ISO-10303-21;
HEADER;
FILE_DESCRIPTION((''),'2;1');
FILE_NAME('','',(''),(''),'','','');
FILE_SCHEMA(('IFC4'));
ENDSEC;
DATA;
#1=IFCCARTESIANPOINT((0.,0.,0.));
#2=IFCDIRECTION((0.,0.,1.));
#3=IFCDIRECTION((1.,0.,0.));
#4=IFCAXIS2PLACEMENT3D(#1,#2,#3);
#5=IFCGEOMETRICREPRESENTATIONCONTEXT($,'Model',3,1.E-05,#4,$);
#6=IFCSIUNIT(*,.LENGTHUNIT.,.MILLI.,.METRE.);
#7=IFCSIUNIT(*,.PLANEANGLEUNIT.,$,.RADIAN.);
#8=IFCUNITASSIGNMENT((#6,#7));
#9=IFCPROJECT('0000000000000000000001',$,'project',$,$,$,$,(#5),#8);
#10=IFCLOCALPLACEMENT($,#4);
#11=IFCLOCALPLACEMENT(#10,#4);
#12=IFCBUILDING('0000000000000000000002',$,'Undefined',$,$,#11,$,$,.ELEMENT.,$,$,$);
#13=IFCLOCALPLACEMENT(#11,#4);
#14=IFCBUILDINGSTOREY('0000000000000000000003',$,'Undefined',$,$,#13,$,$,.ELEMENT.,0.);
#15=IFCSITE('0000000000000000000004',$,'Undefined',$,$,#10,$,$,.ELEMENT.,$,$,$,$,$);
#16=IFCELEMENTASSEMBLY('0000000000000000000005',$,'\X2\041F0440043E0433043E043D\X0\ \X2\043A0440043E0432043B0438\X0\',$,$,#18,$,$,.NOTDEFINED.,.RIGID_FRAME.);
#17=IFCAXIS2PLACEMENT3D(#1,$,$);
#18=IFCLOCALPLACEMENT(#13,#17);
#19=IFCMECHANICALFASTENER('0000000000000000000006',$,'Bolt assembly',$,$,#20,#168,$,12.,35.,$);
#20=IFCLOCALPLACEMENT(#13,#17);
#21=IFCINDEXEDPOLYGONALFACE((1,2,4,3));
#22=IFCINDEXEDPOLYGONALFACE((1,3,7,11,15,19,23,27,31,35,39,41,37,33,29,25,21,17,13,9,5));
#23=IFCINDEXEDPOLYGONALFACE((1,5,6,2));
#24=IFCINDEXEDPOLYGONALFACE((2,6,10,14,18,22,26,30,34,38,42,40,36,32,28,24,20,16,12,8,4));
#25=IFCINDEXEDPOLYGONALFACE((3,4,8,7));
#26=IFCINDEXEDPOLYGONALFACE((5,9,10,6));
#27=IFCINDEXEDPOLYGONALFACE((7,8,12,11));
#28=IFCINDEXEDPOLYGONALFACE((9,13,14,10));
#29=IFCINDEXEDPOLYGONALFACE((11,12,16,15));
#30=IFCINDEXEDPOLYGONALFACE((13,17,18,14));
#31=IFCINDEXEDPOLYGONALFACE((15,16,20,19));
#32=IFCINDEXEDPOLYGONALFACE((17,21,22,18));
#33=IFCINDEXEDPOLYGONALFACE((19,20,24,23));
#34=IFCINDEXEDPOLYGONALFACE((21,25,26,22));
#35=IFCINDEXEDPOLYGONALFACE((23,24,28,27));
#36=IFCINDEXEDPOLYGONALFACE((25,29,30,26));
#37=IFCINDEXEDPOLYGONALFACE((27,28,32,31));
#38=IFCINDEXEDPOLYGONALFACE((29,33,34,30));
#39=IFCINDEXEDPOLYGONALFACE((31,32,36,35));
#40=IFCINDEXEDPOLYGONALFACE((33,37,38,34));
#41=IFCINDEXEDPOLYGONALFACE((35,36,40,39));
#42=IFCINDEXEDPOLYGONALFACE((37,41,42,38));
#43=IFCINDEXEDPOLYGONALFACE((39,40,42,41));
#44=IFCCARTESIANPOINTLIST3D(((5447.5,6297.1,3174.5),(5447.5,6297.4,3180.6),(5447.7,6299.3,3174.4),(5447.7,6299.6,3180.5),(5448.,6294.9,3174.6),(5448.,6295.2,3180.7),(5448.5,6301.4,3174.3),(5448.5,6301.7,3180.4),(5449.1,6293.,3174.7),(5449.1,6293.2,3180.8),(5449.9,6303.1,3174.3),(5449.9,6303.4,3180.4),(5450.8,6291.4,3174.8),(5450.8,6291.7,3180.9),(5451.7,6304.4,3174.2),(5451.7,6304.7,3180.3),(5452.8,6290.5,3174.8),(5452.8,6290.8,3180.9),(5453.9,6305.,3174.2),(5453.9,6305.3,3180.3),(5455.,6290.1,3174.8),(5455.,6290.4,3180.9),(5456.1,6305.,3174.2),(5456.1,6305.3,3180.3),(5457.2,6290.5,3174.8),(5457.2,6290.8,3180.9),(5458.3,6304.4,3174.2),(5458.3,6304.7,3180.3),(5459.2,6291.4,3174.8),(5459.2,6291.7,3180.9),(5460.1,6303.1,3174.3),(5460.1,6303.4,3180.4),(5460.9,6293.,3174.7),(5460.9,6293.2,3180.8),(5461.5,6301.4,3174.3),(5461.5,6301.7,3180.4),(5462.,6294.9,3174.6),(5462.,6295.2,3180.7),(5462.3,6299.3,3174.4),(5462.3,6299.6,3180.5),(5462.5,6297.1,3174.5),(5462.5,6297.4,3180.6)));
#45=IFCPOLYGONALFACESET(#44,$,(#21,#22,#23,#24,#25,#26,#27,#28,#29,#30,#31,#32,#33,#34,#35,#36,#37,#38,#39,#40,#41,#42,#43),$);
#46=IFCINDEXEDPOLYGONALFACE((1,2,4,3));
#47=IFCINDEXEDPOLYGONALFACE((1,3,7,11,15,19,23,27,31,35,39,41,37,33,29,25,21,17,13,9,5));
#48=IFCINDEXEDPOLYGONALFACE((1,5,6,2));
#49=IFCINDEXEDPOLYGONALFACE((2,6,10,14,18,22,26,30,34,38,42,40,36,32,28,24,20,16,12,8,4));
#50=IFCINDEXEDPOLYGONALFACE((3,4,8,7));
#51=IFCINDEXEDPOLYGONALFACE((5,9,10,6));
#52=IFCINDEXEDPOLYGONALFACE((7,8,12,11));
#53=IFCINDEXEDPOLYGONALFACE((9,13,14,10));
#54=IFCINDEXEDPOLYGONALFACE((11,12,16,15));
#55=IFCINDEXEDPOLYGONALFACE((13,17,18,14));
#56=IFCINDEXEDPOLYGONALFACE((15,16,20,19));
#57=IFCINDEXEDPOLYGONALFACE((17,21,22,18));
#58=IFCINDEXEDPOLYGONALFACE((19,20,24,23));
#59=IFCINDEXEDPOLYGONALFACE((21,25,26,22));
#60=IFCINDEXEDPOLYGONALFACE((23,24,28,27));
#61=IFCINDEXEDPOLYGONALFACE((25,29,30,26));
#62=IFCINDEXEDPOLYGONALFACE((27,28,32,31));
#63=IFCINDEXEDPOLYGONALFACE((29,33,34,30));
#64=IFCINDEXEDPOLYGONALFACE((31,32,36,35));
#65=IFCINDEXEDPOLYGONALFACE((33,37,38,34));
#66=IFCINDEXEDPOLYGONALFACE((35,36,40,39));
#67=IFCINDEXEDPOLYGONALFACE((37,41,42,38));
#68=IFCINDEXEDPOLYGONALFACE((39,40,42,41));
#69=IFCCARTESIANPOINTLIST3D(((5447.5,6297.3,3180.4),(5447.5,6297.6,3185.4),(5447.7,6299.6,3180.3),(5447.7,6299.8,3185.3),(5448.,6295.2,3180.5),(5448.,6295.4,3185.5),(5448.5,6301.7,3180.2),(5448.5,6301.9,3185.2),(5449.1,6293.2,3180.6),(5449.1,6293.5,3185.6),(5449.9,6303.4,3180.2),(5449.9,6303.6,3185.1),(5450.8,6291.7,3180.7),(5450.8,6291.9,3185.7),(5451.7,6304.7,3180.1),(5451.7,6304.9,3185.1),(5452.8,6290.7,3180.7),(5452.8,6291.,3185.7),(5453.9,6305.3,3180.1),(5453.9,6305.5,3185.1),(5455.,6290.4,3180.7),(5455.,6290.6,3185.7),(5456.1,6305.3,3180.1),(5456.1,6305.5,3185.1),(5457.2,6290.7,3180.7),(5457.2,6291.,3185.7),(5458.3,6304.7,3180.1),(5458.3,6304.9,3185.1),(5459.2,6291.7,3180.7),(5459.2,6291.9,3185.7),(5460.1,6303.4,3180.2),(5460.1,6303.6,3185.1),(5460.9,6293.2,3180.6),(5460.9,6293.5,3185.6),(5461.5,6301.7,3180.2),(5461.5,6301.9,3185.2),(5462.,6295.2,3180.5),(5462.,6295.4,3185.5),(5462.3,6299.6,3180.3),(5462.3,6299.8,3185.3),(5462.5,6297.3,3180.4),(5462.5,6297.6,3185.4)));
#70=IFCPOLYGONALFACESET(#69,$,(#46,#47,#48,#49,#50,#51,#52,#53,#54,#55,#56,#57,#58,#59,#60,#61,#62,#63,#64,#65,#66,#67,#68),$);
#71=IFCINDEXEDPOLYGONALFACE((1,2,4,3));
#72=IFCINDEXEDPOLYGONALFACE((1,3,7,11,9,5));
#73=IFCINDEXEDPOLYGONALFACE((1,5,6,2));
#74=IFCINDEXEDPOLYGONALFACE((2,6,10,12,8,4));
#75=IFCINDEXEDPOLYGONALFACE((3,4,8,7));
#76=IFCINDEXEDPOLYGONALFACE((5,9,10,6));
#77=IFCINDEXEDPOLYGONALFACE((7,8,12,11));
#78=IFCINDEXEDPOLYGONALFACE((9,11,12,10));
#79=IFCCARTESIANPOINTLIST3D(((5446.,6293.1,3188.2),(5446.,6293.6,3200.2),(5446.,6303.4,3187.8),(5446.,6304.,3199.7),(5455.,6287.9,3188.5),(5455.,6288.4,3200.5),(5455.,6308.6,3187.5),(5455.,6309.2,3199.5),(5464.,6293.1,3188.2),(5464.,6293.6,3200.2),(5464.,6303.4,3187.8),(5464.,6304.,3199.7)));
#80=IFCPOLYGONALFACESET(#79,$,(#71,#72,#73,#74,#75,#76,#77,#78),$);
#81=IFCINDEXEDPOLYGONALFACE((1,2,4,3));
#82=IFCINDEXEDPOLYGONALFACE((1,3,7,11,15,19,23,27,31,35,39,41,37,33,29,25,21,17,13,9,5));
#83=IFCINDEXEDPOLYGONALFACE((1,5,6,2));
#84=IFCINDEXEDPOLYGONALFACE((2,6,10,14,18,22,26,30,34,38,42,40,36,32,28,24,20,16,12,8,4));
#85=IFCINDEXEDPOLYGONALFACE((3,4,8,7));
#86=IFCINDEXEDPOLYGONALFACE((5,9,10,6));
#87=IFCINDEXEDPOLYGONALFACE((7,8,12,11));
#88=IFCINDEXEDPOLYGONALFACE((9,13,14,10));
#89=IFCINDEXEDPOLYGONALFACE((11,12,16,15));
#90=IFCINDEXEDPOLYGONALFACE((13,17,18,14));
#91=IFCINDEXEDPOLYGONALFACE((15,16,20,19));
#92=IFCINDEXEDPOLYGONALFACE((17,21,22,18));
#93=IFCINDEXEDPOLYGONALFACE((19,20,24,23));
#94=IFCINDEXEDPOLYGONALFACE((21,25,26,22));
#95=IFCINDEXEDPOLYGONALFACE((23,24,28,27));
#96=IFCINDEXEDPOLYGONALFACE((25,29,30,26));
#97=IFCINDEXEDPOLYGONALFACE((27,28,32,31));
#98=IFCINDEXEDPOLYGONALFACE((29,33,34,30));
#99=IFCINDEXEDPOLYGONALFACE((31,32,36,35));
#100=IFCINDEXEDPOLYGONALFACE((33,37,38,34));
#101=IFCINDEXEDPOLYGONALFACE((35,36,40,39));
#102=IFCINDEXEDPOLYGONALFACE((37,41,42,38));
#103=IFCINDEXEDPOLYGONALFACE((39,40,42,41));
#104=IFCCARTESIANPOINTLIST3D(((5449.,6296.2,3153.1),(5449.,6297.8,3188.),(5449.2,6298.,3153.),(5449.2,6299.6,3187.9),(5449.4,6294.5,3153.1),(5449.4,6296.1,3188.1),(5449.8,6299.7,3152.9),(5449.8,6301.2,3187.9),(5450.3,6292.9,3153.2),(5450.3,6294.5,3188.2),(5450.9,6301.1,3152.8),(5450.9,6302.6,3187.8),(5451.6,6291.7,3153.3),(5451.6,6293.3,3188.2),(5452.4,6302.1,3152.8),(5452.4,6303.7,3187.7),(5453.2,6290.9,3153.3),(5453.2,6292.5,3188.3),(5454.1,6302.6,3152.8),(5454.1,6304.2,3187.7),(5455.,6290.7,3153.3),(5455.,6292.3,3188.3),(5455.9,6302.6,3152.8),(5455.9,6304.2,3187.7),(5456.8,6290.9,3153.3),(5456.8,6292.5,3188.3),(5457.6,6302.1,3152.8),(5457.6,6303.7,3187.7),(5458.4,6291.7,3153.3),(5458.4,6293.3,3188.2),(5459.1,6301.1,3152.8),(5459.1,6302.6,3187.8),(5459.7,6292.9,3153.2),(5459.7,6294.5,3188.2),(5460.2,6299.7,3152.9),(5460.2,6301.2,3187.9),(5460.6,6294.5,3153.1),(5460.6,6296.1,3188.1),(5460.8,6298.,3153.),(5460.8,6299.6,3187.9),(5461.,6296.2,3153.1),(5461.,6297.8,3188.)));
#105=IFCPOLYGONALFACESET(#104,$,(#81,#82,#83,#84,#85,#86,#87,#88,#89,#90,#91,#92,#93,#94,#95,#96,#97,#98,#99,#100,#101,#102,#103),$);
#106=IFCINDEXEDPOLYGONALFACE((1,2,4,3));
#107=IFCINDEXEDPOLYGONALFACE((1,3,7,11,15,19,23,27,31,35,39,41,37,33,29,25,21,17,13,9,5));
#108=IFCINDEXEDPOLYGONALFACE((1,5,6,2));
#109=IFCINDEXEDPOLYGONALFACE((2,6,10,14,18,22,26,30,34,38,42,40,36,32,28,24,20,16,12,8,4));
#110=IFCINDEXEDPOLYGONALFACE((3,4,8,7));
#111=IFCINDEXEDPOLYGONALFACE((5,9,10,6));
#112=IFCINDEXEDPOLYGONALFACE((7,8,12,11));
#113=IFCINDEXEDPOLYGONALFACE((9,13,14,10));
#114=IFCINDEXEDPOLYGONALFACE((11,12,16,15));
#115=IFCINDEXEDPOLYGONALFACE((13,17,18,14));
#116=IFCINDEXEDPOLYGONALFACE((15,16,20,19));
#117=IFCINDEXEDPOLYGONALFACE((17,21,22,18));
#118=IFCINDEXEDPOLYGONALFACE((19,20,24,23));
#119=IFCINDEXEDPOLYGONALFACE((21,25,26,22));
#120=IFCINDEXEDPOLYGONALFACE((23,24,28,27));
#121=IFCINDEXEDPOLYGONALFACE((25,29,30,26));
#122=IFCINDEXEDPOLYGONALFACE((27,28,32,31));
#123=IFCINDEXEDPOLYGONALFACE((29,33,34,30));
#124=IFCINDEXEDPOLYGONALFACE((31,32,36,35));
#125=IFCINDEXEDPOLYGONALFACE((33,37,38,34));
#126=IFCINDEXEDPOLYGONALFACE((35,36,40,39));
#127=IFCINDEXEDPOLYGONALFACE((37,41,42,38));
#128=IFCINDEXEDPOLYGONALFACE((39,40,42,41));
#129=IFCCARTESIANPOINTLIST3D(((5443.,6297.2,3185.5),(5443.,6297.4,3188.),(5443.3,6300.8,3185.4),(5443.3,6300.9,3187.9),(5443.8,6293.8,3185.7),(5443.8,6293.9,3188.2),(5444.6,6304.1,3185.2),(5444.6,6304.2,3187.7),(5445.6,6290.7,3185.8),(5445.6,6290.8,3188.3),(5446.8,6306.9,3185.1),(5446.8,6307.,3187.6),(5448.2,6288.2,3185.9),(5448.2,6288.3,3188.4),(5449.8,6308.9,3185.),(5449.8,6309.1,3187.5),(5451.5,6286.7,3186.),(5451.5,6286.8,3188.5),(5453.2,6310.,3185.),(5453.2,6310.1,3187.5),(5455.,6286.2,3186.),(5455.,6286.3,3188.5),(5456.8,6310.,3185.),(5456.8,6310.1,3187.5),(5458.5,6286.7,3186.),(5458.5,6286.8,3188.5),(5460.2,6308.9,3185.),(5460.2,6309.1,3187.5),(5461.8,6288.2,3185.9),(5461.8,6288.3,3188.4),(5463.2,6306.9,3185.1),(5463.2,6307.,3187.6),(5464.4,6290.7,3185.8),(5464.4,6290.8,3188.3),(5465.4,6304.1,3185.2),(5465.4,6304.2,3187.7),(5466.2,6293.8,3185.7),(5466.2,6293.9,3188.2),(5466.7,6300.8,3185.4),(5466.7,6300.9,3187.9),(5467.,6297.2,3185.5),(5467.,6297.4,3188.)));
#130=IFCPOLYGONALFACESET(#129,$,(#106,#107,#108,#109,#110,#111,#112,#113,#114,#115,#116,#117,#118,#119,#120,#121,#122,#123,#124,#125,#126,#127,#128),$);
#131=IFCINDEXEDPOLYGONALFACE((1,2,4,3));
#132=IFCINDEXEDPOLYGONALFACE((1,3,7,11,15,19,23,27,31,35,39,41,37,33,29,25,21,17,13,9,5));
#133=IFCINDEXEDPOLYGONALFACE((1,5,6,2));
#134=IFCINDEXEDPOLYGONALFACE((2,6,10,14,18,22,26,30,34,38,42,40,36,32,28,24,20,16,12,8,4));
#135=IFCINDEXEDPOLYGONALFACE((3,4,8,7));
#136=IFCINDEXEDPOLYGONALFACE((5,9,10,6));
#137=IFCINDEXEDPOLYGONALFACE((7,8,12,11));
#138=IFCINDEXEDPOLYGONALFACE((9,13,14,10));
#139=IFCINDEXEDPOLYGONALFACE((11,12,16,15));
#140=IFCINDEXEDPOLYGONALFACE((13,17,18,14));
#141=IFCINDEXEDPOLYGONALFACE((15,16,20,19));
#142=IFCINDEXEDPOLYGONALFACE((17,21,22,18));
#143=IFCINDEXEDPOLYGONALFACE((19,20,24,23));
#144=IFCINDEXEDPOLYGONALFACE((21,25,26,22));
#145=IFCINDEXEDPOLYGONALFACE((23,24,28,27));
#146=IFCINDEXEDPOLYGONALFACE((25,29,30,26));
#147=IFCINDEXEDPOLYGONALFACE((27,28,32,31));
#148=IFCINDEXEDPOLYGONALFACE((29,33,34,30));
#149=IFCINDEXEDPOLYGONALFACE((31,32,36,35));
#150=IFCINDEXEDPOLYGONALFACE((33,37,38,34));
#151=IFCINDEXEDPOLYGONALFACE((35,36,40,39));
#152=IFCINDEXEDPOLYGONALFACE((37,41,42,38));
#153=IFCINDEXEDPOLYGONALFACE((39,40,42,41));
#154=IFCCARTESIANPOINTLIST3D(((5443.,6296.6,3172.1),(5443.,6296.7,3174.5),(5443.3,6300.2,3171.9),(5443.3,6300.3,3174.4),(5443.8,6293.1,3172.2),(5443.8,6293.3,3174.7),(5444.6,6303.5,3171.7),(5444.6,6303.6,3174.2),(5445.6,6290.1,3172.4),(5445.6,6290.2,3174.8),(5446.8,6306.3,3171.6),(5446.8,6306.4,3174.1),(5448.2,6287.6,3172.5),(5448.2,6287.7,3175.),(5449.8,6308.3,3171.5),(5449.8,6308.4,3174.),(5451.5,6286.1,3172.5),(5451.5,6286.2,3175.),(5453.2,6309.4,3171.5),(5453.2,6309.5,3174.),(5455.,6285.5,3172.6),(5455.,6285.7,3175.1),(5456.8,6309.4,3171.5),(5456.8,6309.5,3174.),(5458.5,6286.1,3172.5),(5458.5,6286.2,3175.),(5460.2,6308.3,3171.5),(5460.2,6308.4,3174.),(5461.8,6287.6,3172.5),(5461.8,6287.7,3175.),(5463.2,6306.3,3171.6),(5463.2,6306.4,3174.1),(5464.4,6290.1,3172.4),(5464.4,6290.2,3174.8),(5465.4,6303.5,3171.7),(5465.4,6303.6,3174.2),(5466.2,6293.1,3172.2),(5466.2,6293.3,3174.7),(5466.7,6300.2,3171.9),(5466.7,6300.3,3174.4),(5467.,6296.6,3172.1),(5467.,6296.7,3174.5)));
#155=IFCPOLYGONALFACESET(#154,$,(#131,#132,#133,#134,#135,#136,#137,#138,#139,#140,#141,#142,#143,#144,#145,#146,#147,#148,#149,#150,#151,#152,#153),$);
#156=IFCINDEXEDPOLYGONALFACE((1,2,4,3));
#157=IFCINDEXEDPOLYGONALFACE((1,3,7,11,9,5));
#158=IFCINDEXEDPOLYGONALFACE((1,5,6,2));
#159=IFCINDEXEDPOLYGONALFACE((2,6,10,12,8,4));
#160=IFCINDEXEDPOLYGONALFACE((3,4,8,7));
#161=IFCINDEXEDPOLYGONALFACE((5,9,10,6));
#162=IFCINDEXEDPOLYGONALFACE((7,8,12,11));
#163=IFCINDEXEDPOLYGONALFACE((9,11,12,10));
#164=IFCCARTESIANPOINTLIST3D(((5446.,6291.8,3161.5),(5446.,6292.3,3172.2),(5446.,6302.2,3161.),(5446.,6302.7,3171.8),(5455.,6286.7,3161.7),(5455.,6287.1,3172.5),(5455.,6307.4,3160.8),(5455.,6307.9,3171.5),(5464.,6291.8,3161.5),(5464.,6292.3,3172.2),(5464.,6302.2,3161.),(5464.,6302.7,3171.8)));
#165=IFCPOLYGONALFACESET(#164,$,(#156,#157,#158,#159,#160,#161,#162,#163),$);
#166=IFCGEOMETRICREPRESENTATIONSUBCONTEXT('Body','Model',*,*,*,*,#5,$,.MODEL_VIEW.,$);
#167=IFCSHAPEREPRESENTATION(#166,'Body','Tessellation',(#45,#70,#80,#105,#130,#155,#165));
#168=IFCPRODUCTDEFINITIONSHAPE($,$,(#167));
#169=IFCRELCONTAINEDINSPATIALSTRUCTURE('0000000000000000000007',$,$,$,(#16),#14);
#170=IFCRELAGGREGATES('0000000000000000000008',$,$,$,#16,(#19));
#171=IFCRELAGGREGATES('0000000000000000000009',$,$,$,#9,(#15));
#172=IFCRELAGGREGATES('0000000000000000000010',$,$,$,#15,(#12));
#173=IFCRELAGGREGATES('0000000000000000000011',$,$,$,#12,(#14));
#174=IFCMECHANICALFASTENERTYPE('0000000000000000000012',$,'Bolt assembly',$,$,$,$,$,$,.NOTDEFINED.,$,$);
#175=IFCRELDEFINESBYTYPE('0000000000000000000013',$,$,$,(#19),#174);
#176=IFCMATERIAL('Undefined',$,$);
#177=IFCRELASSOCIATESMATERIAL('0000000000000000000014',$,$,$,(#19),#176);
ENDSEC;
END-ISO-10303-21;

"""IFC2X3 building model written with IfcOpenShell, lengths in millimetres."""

from ifc_helpers import new_model, si_unit, frame, origin_with_axes, origin_2d_with_axis, place, context, subcontext, project, spatial, polyline, circle, outline, extrude, source, transform, mapped, material, type_object, element, aggregate, save


model = new_model("IFC2X3")

# Units and contexts
model_context = context("Model", 3, precision=1e-05, world=origin_with_axes())
body_context = subcontext(model_context, "Body", "Model", "MODEL_VIEW")
ifc_project = project(units=[si_unit("LENGTHUNIT", "METRE", prefix="MILLI"), si_unit("PLANEANGLEUNIT", "RADIAN")], contexts=[model_context])

# Site, building, storey
site_placement = place(None, origin_with_axes())
site = spatial("IfcSite", under=ifc_project, at=site_placement, Name="Undefined", CompositionType="ELEMENT")
building_placement = place(site_placement, origin_with_axes())
building = spatial("IfcBuilding", under=site, at=building_placement, Name="Undefined", CompositionType="ELEMENT")
storey_placement = place(building_placement, origin_with_axes())
storey = spatial("IfcBuildingStorey", under=building, at=storey_placement, Name="Undefined", CompositionType="ELEMENT", Elevation=0.0)

# Element assembly
assembly_1_placement = place(storey_placement, origin_with_axes())
assembly_1 = element("IfcElementAssembly", 1, at=assembly_1_placement, inside=storey, Name="Прогон кровли", AssemblyPlace="NOTDEFINED", PredefinedType="RIGID_FRAME")

# Mechanical fastener
ifc_material_1 = material(Name="Undefined")
mechanical_fastener_type = type_object("IfcMechanicalFastenerType", Name="Bolt assembly")
shared_shape_1 = source(origin_with_axes(), body_context, "Body", "SweptSolid", [
    extrude(circle(Radius=7.5, at=origin_2d_with_axis()), frame((0.0, -0.1, 0.0), z_axis=(0.0, 1.0, 0.0), x_axis=(1.0, 0.0, 0.0)), (0.0, 0.0, 1.0), 6.1),
    extrude(circle(Radius=7.5, at=origin_2d_with_axis()), frame((0.0, -4.9, 0.0), z_axis=(0.0, 1.0, 0.0), x_axis=(1.0, 0.0, 0.0)), (0.0, 0.0, 1.0), 5.0),
    extrude(outline(polyline([(10.4, 0.0), (5.2, 9.0), (-5.2, 9.0), (-10.4, 0.0), (-5.2, -9.0), (5.2, -9.0), (10.4, 0.0)])), frame((0.0, -19.5, 0.0), z_axis=(0.0, 1.0, 0.0), x_axis=(1.0, 0.0, 0.0)), (0.0, 0.0, 1.0), 12.0),
    extrude(circle(Radius=6.0, at=origin_2d_with_axis()), frame((0.0, -7.5, 0.0), z_axis=(0.0, 1.0, 0.0), x_axis=(1.0, 0.0, 0.0)), (0.0, 0.0, 1.0), 35.0),
    extrude(circle(Radius=12.0, at=origin_2d_with_axis()), frame((0.0, -7.5, 0.0), z_axis=(0.0, 1.0, 0.0), x_axis=(1.0, 0.0, 0.0)), (0.0, 0.0, 1.0), 2.5),
    extrude(circle(Radius=12.0, at=origin_2d_with_axis()), frame((0.0, 6.0, 0.0), z_axis=(0.0, 1.0, 0.0), x_axis=(1.0, 0.0, 0.0)), (0.0, 0.0, 1.0), 2.5),
    extrude(outline(polyline([(10.4, 0.0), (5.2, 9.0), (-5.2, 9.0), (-10.4, 0.0), (-5.2, -9.0), (5.2, -9.0), (10.4, 0.0)])), frame((0.0, 8.5, 0.0), z_axis=(0.0, 1.0, 0.0), x_axis=(1.0, 0.0, 0.0)), (0.0, 0.0, 1.0), 10.8),
])
mechanical_fastener_1_placement = place(assembly_1_placement, frame((5455.0, 6297.9, 3180.5), z_axis=(1.0, 0.0, 0.0), x_axis=(0.0, -0.998969, 0.045408)))
mechanical_fastener_1 = element("IfcMechanicalFastener", 2, at=mechanical_fastener_1_placement, type_object=mechanical_fastener_type, material=ifc_material_1, Name="Bolt assembly", NominalDiameter=12.0, NominalLength=35.0, context=body_context, shape_type="MappedRepresentation", body=[
    mapped(shared_shape_1, transform((0.0, 0.0, 0.0))),
])
aggregate(assembly_1, [mechanical_fastener_1])

save(model, "model.ifc")
